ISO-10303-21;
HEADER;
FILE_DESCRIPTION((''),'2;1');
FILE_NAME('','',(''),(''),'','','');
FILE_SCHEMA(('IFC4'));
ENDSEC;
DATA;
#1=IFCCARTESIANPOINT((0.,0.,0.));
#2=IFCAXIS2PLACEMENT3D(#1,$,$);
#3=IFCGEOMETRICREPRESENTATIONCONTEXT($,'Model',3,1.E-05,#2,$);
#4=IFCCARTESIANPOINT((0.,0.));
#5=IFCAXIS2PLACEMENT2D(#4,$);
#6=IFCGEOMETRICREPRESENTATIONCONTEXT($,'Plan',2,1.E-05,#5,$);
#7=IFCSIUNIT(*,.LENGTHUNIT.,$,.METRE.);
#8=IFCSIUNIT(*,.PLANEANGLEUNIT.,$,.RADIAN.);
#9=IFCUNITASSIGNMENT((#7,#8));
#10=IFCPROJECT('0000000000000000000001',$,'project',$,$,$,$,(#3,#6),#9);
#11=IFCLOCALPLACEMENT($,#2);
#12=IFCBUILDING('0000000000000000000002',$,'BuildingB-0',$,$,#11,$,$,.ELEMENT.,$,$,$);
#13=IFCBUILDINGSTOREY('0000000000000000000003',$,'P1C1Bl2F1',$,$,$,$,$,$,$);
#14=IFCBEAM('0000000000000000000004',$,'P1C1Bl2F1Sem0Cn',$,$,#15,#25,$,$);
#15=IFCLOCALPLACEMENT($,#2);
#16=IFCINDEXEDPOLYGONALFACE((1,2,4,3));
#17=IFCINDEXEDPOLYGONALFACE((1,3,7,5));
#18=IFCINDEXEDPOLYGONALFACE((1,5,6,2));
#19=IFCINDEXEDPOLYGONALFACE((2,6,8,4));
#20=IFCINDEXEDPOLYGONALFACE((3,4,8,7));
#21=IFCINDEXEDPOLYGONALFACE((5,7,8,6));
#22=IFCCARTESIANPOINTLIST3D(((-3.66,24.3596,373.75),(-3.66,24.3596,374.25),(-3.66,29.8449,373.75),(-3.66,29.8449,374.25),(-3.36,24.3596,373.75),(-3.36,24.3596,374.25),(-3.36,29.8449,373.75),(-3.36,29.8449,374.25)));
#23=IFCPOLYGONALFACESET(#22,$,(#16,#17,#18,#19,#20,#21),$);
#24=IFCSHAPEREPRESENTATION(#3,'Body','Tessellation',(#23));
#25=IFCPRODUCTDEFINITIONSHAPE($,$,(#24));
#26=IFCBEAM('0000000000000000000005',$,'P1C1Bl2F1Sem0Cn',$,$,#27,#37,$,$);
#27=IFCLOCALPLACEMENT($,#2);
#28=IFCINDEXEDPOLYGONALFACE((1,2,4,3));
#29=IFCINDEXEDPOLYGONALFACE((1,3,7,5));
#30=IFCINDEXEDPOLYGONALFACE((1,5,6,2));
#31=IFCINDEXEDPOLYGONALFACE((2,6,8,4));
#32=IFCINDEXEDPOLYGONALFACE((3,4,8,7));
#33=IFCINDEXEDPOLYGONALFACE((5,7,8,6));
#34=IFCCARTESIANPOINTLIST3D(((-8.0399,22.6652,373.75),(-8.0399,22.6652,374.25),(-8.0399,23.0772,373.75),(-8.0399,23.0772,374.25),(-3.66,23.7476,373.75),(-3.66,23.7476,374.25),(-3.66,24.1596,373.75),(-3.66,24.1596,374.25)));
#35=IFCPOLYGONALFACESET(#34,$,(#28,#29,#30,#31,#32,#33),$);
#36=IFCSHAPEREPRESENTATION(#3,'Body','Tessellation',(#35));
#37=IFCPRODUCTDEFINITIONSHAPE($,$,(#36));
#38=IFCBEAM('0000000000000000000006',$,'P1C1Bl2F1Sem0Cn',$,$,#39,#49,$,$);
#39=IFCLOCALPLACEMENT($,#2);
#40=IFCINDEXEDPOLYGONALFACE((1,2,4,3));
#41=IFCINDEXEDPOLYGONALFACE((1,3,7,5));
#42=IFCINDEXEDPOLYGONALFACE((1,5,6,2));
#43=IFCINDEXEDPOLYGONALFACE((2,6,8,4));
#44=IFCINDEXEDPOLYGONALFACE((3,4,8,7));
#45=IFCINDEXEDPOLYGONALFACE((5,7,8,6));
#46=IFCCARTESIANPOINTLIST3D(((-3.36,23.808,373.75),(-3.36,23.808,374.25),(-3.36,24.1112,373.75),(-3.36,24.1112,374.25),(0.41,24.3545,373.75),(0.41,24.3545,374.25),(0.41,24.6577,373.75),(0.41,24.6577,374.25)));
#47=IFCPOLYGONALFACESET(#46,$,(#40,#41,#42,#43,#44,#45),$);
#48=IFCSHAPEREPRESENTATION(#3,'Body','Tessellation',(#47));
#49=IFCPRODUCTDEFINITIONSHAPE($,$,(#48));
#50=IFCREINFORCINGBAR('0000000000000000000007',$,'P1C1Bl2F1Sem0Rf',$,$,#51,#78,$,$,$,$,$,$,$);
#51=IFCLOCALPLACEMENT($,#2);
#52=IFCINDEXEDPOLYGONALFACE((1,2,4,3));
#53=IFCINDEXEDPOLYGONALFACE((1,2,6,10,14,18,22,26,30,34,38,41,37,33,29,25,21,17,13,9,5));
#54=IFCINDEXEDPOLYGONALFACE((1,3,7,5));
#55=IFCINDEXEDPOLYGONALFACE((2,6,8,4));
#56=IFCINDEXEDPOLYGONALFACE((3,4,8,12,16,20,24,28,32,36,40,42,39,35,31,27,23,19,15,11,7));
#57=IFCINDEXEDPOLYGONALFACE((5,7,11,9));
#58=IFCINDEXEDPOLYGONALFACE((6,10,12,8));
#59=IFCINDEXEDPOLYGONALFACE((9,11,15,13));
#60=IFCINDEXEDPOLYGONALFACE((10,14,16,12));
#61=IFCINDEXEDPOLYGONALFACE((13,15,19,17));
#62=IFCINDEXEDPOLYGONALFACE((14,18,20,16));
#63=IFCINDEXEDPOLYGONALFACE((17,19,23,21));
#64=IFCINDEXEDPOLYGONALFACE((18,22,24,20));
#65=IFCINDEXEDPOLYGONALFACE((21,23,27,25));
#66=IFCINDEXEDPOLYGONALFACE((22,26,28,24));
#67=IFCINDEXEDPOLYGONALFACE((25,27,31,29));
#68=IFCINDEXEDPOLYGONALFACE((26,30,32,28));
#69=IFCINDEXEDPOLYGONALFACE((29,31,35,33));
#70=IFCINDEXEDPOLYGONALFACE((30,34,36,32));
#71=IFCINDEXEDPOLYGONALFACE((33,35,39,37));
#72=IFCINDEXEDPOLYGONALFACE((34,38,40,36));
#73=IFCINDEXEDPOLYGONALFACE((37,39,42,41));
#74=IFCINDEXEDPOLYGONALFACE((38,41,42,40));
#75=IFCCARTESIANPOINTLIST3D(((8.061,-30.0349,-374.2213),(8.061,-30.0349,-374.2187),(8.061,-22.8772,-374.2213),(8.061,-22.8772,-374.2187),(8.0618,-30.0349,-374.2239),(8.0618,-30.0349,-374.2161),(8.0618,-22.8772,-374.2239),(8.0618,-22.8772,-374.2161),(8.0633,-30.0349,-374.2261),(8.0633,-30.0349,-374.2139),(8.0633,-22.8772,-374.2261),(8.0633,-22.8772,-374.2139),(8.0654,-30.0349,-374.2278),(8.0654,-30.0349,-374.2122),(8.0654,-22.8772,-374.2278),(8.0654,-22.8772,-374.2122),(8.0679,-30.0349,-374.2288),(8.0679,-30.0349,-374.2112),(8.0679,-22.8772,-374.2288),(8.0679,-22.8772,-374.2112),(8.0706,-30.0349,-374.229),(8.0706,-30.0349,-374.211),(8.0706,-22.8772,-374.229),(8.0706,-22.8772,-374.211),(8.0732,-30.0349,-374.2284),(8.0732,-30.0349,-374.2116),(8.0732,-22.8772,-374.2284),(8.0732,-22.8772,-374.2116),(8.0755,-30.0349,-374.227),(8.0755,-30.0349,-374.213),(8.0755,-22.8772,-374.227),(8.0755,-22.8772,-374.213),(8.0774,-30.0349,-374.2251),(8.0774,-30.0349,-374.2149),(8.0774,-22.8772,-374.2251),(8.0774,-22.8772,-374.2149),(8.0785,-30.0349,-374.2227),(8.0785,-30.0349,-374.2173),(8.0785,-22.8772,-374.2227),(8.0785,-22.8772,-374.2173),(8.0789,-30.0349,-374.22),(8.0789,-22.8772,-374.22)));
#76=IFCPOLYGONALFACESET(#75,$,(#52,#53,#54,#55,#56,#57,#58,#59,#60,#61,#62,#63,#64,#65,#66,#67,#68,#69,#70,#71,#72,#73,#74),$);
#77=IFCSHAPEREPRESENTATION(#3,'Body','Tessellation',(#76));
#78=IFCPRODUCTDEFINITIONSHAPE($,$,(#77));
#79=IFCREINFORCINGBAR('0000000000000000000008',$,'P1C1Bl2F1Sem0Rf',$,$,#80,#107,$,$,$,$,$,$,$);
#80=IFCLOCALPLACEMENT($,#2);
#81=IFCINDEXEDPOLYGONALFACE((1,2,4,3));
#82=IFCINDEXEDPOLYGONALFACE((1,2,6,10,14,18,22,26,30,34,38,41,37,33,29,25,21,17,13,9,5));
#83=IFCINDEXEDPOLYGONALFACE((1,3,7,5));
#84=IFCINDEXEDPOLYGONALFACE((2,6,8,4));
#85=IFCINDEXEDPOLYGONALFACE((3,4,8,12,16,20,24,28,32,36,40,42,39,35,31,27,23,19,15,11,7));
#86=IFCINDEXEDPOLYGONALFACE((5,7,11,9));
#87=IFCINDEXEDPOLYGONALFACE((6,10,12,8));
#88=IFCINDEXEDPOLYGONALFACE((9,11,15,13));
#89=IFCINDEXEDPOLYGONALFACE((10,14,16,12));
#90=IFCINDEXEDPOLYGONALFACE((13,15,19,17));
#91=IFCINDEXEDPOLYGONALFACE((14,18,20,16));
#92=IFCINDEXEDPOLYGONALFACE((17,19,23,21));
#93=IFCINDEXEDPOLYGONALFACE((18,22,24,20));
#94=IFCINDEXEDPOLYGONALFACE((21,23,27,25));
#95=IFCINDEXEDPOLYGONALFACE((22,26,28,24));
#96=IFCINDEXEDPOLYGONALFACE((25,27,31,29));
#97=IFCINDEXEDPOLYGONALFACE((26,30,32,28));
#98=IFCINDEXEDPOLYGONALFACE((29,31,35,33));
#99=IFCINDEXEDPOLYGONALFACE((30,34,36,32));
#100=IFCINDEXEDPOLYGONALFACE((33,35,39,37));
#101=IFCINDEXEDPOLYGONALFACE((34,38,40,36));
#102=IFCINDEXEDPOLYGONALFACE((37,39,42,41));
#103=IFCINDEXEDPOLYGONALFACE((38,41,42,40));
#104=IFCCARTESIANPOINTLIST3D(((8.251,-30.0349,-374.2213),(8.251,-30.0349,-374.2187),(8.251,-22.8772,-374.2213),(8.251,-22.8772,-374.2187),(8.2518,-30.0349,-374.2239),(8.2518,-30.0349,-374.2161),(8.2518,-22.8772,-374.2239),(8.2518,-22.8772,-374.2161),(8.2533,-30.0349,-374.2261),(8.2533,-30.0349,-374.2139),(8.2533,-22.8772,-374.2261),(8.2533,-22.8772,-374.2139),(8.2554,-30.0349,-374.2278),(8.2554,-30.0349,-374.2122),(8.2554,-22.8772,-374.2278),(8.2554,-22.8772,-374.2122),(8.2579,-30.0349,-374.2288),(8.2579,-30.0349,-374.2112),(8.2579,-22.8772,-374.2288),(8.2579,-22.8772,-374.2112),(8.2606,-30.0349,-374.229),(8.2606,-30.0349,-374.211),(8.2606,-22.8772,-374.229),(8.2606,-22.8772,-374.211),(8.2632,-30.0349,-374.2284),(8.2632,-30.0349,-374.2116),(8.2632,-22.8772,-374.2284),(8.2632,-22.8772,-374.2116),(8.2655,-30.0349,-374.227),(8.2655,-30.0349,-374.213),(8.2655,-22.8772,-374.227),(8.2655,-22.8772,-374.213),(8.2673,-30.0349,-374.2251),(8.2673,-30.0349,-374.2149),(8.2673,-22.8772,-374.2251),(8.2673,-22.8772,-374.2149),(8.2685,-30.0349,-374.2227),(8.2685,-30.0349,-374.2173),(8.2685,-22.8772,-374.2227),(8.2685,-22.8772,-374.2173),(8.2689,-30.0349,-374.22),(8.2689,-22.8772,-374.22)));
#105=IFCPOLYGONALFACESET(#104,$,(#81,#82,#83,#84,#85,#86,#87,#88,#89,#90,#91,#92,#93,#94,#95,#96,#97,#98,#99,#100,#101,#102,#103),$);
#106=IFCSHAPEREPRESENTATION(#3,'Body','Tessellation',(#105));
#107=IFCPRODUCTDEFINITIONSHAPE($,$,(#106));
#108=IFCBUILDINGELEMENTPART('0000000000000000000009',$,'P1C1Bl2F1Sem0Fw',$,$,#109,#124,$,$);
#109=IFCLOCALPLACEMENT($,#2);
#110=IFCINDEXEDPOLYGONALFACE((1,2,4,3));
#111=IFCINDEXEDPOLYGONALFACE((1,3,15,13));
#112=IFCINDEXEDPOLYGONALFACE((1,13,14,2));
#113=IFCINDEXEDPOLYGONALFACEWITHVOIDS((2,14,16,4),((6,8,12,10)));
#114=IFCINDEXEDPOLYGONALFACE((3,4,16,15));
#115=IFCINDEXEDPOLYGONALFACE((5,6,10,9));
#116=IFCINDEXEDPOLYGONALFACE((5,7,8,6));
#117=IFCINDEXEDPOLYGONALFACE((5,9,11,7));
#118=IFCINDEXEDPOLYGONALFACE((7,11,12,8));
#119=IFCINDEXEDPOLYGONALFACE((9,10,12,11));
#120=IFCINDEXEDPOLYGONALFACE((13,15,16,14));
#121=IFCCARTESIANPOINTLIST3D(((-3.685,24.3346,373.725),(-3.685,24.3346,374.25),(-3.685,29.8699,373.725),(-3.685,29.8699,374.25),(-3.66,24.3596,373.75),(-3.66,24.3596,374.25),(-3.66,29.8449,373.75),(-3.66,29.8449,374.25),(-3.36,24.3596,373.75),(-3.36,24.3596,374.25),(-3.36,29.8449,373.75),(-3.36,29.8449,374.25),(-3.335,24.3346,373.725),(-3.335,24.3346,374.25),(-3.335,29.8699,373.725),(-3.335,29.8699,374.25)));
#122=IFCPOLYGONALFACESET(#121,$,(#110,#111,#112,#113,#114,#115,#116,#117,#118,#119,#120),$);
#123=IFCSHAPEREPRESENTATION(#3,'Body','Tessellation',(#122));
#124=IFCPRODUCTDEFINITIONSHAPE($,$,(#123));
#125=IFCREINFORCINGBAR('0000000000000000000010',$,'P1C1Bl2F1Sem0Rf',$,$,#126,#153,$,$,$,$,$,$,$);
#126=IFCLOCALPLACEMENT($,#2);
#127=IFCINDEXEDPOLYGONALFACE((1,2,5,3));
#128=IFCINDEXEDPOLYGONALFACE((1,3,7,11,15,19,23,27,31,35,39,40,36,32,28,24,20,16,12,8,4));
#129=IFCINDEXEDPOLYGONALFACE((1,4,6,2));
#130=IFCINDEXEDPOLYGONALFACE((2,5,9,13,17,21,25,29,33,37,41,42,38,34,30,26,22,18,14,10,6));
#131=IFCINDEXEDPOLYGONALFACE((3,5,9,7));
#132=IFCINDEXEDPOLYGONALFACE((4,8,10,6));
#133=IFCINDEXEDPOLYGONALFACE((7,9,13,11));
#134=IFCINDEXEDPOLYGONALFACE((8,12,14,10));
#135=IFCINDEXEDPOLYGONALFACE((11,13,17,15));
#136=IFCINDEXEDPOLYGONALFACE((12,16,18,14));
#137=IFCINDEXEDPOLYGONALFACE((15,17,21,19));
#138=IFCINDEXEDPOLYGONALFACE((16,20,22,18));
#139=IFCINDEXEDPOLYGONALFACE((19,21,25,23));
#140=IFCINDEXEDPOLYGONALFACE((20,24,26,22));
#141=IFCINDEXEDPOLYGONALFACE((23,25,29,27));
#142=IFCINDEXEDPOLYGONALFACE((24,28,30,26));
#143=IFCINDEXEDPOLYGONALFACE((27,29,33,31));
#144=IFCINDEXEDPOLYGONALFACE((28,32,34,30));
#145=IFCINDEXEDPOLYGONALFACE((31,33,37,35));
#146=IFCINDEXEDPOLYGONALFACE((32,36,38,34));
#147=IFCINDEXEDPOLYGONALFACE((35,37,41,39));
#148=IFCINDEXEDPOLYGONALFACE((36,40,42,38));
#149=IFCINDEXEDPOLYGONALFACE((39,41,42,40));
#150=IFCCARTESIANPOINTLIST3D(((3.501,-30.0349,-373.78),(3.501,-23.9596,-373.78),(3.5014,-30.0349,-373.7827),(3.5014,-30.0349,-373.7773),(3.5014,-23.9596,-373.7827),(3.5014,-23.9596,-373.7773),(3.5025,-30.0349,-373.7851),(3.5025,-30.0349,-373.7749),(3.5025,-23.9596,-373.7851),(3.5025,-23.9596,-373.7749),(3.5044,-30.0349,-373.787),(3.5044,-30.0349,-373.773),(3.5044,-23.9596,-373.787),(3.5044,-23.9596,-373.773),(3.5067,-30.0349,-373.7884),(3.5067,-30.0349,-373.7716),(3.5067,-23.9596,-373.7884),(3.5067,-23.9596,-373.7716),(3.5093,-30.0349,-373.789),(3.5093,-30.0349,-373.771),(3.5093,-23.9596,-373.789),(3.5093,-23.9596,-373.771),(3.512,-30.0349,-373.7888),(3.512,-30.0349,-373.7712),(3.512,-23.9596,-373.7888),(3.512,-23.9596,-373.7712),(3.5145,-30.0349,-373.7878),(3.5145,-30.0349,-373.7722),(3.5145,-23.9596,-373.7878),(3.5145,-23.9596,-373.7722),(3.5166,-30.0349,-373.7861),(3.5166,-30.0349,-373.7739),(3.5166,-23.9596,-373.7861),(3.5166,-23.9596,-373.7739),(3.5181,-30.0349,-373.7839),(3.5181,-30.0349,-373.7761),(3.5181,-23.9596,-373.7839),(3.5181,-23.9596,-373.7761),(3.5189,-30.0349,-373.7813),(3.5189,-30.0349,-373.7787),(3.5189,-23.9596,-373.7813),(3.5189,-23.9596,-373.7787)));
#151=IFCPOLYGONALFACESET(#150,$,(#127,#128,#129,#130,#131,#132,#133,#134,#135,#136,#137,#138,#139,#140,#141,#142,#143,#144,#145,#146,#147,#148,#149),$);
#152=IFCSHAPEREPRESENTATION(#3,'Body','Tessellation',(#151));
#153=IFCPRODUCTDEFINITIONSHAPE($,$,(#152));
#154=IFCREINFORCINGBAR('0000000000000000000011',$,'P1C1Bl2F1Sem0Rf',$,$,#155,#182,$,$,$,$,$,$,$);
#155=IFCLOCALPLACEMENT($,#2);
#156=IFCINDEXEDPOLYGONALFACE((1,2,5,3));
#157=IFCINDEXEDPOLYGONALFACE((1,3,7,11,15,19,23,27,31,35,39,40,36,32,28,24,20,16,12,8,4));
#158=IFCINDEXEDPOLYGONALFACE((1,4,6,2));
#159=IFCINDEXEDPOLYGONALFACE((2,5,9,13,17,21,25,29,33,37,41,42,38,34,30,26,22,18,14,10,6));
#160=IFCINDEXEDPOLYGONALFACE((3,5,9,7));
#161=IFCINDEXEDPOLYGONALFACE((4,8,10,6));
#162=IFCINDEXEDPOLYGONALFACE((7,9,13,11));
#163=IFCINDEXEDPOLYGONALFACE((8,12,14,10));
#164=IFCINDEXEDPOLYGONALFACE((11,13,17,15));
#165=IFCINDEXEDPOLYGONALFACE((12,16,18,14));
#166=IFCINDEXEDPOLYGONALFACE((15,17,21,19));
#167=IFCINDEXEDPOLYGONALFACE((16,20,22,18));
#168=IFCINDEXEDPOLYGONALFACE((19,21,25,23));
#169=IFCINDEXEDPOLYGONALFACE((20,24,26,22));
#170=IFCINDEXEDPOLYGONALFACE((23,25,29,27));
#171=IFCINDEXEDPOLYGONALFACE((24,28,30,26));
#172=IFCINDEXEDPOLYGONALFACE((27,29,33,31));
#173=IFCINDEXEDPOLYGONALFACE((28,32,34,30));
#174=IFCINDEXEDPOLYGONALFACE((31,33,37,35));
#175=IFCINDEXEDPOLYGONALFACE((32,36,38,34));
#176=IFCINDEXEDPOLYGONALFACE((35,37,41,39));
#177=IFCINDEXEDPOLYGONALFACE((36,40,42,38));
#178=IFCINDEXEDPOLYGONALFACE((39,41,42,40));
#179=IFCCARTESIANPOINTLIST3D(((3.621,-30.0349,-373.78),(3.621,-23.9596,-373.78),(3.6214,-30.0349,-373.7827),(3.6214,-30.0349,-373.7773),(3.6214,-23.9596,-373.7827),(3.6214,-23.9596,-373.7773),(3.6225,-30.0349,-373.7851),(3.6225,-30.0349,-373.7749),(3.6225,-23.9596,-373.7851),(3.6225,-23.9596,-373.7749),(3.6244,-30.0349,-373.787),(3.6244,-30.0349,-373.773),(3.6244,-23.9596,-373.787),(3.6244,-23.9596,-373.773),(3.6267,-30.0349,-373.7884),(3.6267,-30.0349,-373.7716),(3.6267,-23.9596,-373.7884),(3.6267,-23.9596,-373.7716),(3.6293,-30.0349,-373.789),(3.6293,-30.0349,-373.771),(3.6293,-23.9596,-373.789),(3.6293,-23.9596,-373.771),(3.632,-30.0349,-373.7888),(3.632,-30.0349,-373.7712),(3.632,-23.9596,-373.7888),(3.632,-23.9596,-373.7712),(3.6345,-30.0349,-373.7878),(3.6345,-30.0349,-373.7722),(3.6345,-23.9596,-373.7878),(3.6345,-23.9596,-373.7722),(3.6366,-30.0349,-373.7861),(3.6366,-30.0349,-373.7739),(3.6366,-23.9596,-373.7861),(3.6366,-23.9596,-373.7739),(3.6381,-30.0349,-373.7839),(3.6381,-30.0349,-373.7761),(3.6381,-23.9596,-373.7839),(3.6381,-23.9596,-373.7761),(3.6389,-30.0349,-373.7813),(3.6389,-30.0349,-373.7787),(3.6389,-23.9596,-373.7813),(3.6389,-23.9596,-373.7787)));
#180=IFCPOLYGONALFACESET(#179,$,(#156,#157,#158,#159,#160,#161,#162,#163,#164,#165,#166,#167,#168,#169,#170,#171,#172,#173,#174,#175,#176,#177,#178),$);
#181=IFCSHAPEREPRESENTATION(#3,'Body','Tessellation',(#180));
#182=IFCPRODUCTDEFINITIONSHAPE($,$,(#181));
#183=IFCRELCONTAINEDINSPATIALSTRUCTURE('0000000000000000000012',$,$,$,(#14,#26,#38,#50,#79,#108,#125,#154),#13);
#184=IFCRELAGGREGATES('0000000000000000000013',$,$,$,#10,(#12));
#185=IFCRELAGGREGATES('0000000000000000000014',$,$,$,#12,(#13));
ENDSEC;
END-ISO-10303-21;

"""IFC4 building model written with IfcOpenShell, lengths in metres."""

from ifc_helpers import new_model, entity, si_unit, origin, origin_2d, place, context, project, spatial, polyline, outline, extrude, element, save


model = new_model("IFC4")

# Units and contexts
model_context = context("Model", 3, precision=1e-05, world=origin())
plan_context = context("Plan", 2, precision=1e-05, world=origin_2d())
ifc_project = project(units=[si_unit("LENGTHUNIT", "METRE"), si_unit("PLANEANGLEUNIT", "RADIAN")], contexts=[model_context, plan_context])

# Building, storey
building_placement = place(None, origin())
building = spatial("IfcBuilding", under=ifc_project, at=building_placement, Name="BuildingB-0", CompositionType="ELEMENT")
storey = spatial("IfcBuildingStorey", under=building, Name="P1C1Bl2F1")

# Beams
element("IfcBeam", 1, inside=storey, Name="P1C1Bl2F1Sem0Cn", context=model_context, shape_type="SweptSolid", body=[
    extrude(outline(polyline([(-3.66, 29.8449, 373.75), (-3.36, 29.8449, 373.75), (-3.36, 24.3596, 373.75), (-3.66, 24.3596, 373.75), (-3.66, 29.8449, 373.75)])), None, (0.0, 0.0, 1.0), 0.5),
])
element("IfcBeam", 2, inside=storey, Name="P1C1Bl2F1Sem0Cn", context=model_context, shape_type="SweptSolid", body=[
    extrude(outline(polyline([(-3.66, 24.1596, 373.75), (-3.66, 23.7476, 373.75), (-8.0399, 22.6652, 373.75), (-8.0399, 23.0772, 373.75), (-3.66, 24.1596, 373.75)])), None, (0.0, 0.0, 1.0), 0.5),
])
element("IfcBeam", 3, inside=storey, Name="P1C1Bl2F1Sem0Cn", context=model_context, shape_type="SweptSolid", body=[
    extrude(outline(polyline([(-3.36, 23.808, 373.75), (0.41, 24.3545, 373.75), (0.41, 24.6577, 373.75), (-3.36, 24.1112, 373.75), (-3.36, 23.808, 373.75)])), None, (0.0, 0.0, 1.0), 0.5),
])

# Reinforcing bars
element("IfcReinforcingBar", 4, inside=storey, Name="P1C1Bl2F1Sem0Rf", context=model_context, shape_type="SweptSolid", body=[
    entity("IfcSurfaceCurveSweptAreaSolid", entity("IfcCircleProfileDef", "AREA", None, None, 0.009), None, entity("IfcPolyline", [entity("IfcCartesianPoint", [-8.0699, 22.8772, 374.22]), entity("IfcCartesianPoint", [-8.0699, 30.0349, 374.22])]), None, None, entity("IfcPlane", entity("IfcAxis2Placement3D", entity("IfcCartesianPoint", [-8.0699, 22.8772, 374.22]), entity("IfcDirection", [0.0, 0.0, 1.0]), entity("IfcDirection", [1.0, 0.0, 0.0])))),
])
element("IfcReinforcingBar", 5, inside=storey, Name="P1C1Bl2F1Sem0Rf", context=model_context, shape_type="SweptSolid", body=[
    entity("IfcSurfaceCurveSweptAreaSolid", entity("IfcCircleProfileDef", "AREA", None, None, 0.009), None, entity("IfcPolyline", [entity("IfcCartesianPoint", [-8.2599, 22.8772, 374.22]), entity("IfcCartesianPoint", [-8.2599, 30.0349, 374.22])]), None, None, entity("IfcPlane", entity("IfcAxis2Placement3D", entity("IfcCartesianPoint", [-8.2599, 22.8772, 374.22]), entity("IfcDirection", [0.0, 0.0, 1.0]), entity("IfcDirection", [1.0, 0.0, 0.0])))),
])

# Building element part, opening
building_element_part_1 = element("IfcBuildingElementPart", 6, inside=storey, Name="P1C1Bl2F1Sem0Fw", context=model_context, shape_type="SweptSolid", body=[
    extrude(outline(polyline([(-3.685, 29.8699, 373.725), (-3.335, 29.8699, 373.725), (-3.335, 24.3346, 373.725), (-3.685, 24.3346, 373.725), (-3.685, 29.8699, 373.725)])), None, (0.0, 0.0, 1.0), 0.525),
])
element("IfcOpeningElement", 7, inside=storey, cuts=building_element_part_1, context=model_context, shape_type="SweptSolid", body=[
    extrude(outline(polyline([(-3.66, 29.8449, 373.75), (-3.36, 29.8449, 373.75), (-3.36, 24.3596, 373.75), (-3.66, 24.3596, 373.75), (-3.66, 29.8449, 373.75)])), None, (0.0, 0.0, 1.0), 0.5),
])

# Reinforcing bars
element("IfcReinforcingBar", 8, inside=storey, Name="P1C1Bl2F1Sem0Rf", context=model_context, shape_type="SweptSolid", body=[
    entity("IfcSurfaceCurveSweptAreaSolid", entity("IfcCircleProfileDef", "AREA", None, None, 0.009), None, entity("IfcPolyline", [entity("IfcCartesianPoint", [-3.51, 30.0349, 373.78]), entity("IfcCartesianPoint", [-3.51, 23.9596, 373.78])]), None, None, entity("IfcPlane", entity("IfcAxis2Placement3D", entity("IfcCartesianPoint", [-3.51, 30.0349, 373.78]), entity("IfcDirection", [0.0, 0.0, 1.0]), entity("IfcDirection", [1.0, 0.0, 0.0])))),
])
element("IfcReinforcingBar", 9, inside=storey, Name="P1C1Bl2F1Sem0Rf", context=model_context, shape_type="SweptSolid", body=[
    entity("IfcSurfaceCurveSweptAreaSolid", entity("IfcCircleProfileDef", "AREA", None, None, 0.009), None, entity("IfcPolyline", [entity("IfcCartesianPoint", [-3.63, 30.0349, 373.78]), entity("IfcCartesianPoint", [-3.63, 23.9596, 373.78])]), None, None, entity("IfcPlane", entity("IfcAxis2Placement3D", entity("IfcCartesianPoint", [-3.63, 30.0349, 373.78]), entity("IfcDirection", [0.0, 0.0, 1.0]), entity("IfcDirection", [1.0, 0.0, 0.0])))),
])

save(model, "model.ifc")
